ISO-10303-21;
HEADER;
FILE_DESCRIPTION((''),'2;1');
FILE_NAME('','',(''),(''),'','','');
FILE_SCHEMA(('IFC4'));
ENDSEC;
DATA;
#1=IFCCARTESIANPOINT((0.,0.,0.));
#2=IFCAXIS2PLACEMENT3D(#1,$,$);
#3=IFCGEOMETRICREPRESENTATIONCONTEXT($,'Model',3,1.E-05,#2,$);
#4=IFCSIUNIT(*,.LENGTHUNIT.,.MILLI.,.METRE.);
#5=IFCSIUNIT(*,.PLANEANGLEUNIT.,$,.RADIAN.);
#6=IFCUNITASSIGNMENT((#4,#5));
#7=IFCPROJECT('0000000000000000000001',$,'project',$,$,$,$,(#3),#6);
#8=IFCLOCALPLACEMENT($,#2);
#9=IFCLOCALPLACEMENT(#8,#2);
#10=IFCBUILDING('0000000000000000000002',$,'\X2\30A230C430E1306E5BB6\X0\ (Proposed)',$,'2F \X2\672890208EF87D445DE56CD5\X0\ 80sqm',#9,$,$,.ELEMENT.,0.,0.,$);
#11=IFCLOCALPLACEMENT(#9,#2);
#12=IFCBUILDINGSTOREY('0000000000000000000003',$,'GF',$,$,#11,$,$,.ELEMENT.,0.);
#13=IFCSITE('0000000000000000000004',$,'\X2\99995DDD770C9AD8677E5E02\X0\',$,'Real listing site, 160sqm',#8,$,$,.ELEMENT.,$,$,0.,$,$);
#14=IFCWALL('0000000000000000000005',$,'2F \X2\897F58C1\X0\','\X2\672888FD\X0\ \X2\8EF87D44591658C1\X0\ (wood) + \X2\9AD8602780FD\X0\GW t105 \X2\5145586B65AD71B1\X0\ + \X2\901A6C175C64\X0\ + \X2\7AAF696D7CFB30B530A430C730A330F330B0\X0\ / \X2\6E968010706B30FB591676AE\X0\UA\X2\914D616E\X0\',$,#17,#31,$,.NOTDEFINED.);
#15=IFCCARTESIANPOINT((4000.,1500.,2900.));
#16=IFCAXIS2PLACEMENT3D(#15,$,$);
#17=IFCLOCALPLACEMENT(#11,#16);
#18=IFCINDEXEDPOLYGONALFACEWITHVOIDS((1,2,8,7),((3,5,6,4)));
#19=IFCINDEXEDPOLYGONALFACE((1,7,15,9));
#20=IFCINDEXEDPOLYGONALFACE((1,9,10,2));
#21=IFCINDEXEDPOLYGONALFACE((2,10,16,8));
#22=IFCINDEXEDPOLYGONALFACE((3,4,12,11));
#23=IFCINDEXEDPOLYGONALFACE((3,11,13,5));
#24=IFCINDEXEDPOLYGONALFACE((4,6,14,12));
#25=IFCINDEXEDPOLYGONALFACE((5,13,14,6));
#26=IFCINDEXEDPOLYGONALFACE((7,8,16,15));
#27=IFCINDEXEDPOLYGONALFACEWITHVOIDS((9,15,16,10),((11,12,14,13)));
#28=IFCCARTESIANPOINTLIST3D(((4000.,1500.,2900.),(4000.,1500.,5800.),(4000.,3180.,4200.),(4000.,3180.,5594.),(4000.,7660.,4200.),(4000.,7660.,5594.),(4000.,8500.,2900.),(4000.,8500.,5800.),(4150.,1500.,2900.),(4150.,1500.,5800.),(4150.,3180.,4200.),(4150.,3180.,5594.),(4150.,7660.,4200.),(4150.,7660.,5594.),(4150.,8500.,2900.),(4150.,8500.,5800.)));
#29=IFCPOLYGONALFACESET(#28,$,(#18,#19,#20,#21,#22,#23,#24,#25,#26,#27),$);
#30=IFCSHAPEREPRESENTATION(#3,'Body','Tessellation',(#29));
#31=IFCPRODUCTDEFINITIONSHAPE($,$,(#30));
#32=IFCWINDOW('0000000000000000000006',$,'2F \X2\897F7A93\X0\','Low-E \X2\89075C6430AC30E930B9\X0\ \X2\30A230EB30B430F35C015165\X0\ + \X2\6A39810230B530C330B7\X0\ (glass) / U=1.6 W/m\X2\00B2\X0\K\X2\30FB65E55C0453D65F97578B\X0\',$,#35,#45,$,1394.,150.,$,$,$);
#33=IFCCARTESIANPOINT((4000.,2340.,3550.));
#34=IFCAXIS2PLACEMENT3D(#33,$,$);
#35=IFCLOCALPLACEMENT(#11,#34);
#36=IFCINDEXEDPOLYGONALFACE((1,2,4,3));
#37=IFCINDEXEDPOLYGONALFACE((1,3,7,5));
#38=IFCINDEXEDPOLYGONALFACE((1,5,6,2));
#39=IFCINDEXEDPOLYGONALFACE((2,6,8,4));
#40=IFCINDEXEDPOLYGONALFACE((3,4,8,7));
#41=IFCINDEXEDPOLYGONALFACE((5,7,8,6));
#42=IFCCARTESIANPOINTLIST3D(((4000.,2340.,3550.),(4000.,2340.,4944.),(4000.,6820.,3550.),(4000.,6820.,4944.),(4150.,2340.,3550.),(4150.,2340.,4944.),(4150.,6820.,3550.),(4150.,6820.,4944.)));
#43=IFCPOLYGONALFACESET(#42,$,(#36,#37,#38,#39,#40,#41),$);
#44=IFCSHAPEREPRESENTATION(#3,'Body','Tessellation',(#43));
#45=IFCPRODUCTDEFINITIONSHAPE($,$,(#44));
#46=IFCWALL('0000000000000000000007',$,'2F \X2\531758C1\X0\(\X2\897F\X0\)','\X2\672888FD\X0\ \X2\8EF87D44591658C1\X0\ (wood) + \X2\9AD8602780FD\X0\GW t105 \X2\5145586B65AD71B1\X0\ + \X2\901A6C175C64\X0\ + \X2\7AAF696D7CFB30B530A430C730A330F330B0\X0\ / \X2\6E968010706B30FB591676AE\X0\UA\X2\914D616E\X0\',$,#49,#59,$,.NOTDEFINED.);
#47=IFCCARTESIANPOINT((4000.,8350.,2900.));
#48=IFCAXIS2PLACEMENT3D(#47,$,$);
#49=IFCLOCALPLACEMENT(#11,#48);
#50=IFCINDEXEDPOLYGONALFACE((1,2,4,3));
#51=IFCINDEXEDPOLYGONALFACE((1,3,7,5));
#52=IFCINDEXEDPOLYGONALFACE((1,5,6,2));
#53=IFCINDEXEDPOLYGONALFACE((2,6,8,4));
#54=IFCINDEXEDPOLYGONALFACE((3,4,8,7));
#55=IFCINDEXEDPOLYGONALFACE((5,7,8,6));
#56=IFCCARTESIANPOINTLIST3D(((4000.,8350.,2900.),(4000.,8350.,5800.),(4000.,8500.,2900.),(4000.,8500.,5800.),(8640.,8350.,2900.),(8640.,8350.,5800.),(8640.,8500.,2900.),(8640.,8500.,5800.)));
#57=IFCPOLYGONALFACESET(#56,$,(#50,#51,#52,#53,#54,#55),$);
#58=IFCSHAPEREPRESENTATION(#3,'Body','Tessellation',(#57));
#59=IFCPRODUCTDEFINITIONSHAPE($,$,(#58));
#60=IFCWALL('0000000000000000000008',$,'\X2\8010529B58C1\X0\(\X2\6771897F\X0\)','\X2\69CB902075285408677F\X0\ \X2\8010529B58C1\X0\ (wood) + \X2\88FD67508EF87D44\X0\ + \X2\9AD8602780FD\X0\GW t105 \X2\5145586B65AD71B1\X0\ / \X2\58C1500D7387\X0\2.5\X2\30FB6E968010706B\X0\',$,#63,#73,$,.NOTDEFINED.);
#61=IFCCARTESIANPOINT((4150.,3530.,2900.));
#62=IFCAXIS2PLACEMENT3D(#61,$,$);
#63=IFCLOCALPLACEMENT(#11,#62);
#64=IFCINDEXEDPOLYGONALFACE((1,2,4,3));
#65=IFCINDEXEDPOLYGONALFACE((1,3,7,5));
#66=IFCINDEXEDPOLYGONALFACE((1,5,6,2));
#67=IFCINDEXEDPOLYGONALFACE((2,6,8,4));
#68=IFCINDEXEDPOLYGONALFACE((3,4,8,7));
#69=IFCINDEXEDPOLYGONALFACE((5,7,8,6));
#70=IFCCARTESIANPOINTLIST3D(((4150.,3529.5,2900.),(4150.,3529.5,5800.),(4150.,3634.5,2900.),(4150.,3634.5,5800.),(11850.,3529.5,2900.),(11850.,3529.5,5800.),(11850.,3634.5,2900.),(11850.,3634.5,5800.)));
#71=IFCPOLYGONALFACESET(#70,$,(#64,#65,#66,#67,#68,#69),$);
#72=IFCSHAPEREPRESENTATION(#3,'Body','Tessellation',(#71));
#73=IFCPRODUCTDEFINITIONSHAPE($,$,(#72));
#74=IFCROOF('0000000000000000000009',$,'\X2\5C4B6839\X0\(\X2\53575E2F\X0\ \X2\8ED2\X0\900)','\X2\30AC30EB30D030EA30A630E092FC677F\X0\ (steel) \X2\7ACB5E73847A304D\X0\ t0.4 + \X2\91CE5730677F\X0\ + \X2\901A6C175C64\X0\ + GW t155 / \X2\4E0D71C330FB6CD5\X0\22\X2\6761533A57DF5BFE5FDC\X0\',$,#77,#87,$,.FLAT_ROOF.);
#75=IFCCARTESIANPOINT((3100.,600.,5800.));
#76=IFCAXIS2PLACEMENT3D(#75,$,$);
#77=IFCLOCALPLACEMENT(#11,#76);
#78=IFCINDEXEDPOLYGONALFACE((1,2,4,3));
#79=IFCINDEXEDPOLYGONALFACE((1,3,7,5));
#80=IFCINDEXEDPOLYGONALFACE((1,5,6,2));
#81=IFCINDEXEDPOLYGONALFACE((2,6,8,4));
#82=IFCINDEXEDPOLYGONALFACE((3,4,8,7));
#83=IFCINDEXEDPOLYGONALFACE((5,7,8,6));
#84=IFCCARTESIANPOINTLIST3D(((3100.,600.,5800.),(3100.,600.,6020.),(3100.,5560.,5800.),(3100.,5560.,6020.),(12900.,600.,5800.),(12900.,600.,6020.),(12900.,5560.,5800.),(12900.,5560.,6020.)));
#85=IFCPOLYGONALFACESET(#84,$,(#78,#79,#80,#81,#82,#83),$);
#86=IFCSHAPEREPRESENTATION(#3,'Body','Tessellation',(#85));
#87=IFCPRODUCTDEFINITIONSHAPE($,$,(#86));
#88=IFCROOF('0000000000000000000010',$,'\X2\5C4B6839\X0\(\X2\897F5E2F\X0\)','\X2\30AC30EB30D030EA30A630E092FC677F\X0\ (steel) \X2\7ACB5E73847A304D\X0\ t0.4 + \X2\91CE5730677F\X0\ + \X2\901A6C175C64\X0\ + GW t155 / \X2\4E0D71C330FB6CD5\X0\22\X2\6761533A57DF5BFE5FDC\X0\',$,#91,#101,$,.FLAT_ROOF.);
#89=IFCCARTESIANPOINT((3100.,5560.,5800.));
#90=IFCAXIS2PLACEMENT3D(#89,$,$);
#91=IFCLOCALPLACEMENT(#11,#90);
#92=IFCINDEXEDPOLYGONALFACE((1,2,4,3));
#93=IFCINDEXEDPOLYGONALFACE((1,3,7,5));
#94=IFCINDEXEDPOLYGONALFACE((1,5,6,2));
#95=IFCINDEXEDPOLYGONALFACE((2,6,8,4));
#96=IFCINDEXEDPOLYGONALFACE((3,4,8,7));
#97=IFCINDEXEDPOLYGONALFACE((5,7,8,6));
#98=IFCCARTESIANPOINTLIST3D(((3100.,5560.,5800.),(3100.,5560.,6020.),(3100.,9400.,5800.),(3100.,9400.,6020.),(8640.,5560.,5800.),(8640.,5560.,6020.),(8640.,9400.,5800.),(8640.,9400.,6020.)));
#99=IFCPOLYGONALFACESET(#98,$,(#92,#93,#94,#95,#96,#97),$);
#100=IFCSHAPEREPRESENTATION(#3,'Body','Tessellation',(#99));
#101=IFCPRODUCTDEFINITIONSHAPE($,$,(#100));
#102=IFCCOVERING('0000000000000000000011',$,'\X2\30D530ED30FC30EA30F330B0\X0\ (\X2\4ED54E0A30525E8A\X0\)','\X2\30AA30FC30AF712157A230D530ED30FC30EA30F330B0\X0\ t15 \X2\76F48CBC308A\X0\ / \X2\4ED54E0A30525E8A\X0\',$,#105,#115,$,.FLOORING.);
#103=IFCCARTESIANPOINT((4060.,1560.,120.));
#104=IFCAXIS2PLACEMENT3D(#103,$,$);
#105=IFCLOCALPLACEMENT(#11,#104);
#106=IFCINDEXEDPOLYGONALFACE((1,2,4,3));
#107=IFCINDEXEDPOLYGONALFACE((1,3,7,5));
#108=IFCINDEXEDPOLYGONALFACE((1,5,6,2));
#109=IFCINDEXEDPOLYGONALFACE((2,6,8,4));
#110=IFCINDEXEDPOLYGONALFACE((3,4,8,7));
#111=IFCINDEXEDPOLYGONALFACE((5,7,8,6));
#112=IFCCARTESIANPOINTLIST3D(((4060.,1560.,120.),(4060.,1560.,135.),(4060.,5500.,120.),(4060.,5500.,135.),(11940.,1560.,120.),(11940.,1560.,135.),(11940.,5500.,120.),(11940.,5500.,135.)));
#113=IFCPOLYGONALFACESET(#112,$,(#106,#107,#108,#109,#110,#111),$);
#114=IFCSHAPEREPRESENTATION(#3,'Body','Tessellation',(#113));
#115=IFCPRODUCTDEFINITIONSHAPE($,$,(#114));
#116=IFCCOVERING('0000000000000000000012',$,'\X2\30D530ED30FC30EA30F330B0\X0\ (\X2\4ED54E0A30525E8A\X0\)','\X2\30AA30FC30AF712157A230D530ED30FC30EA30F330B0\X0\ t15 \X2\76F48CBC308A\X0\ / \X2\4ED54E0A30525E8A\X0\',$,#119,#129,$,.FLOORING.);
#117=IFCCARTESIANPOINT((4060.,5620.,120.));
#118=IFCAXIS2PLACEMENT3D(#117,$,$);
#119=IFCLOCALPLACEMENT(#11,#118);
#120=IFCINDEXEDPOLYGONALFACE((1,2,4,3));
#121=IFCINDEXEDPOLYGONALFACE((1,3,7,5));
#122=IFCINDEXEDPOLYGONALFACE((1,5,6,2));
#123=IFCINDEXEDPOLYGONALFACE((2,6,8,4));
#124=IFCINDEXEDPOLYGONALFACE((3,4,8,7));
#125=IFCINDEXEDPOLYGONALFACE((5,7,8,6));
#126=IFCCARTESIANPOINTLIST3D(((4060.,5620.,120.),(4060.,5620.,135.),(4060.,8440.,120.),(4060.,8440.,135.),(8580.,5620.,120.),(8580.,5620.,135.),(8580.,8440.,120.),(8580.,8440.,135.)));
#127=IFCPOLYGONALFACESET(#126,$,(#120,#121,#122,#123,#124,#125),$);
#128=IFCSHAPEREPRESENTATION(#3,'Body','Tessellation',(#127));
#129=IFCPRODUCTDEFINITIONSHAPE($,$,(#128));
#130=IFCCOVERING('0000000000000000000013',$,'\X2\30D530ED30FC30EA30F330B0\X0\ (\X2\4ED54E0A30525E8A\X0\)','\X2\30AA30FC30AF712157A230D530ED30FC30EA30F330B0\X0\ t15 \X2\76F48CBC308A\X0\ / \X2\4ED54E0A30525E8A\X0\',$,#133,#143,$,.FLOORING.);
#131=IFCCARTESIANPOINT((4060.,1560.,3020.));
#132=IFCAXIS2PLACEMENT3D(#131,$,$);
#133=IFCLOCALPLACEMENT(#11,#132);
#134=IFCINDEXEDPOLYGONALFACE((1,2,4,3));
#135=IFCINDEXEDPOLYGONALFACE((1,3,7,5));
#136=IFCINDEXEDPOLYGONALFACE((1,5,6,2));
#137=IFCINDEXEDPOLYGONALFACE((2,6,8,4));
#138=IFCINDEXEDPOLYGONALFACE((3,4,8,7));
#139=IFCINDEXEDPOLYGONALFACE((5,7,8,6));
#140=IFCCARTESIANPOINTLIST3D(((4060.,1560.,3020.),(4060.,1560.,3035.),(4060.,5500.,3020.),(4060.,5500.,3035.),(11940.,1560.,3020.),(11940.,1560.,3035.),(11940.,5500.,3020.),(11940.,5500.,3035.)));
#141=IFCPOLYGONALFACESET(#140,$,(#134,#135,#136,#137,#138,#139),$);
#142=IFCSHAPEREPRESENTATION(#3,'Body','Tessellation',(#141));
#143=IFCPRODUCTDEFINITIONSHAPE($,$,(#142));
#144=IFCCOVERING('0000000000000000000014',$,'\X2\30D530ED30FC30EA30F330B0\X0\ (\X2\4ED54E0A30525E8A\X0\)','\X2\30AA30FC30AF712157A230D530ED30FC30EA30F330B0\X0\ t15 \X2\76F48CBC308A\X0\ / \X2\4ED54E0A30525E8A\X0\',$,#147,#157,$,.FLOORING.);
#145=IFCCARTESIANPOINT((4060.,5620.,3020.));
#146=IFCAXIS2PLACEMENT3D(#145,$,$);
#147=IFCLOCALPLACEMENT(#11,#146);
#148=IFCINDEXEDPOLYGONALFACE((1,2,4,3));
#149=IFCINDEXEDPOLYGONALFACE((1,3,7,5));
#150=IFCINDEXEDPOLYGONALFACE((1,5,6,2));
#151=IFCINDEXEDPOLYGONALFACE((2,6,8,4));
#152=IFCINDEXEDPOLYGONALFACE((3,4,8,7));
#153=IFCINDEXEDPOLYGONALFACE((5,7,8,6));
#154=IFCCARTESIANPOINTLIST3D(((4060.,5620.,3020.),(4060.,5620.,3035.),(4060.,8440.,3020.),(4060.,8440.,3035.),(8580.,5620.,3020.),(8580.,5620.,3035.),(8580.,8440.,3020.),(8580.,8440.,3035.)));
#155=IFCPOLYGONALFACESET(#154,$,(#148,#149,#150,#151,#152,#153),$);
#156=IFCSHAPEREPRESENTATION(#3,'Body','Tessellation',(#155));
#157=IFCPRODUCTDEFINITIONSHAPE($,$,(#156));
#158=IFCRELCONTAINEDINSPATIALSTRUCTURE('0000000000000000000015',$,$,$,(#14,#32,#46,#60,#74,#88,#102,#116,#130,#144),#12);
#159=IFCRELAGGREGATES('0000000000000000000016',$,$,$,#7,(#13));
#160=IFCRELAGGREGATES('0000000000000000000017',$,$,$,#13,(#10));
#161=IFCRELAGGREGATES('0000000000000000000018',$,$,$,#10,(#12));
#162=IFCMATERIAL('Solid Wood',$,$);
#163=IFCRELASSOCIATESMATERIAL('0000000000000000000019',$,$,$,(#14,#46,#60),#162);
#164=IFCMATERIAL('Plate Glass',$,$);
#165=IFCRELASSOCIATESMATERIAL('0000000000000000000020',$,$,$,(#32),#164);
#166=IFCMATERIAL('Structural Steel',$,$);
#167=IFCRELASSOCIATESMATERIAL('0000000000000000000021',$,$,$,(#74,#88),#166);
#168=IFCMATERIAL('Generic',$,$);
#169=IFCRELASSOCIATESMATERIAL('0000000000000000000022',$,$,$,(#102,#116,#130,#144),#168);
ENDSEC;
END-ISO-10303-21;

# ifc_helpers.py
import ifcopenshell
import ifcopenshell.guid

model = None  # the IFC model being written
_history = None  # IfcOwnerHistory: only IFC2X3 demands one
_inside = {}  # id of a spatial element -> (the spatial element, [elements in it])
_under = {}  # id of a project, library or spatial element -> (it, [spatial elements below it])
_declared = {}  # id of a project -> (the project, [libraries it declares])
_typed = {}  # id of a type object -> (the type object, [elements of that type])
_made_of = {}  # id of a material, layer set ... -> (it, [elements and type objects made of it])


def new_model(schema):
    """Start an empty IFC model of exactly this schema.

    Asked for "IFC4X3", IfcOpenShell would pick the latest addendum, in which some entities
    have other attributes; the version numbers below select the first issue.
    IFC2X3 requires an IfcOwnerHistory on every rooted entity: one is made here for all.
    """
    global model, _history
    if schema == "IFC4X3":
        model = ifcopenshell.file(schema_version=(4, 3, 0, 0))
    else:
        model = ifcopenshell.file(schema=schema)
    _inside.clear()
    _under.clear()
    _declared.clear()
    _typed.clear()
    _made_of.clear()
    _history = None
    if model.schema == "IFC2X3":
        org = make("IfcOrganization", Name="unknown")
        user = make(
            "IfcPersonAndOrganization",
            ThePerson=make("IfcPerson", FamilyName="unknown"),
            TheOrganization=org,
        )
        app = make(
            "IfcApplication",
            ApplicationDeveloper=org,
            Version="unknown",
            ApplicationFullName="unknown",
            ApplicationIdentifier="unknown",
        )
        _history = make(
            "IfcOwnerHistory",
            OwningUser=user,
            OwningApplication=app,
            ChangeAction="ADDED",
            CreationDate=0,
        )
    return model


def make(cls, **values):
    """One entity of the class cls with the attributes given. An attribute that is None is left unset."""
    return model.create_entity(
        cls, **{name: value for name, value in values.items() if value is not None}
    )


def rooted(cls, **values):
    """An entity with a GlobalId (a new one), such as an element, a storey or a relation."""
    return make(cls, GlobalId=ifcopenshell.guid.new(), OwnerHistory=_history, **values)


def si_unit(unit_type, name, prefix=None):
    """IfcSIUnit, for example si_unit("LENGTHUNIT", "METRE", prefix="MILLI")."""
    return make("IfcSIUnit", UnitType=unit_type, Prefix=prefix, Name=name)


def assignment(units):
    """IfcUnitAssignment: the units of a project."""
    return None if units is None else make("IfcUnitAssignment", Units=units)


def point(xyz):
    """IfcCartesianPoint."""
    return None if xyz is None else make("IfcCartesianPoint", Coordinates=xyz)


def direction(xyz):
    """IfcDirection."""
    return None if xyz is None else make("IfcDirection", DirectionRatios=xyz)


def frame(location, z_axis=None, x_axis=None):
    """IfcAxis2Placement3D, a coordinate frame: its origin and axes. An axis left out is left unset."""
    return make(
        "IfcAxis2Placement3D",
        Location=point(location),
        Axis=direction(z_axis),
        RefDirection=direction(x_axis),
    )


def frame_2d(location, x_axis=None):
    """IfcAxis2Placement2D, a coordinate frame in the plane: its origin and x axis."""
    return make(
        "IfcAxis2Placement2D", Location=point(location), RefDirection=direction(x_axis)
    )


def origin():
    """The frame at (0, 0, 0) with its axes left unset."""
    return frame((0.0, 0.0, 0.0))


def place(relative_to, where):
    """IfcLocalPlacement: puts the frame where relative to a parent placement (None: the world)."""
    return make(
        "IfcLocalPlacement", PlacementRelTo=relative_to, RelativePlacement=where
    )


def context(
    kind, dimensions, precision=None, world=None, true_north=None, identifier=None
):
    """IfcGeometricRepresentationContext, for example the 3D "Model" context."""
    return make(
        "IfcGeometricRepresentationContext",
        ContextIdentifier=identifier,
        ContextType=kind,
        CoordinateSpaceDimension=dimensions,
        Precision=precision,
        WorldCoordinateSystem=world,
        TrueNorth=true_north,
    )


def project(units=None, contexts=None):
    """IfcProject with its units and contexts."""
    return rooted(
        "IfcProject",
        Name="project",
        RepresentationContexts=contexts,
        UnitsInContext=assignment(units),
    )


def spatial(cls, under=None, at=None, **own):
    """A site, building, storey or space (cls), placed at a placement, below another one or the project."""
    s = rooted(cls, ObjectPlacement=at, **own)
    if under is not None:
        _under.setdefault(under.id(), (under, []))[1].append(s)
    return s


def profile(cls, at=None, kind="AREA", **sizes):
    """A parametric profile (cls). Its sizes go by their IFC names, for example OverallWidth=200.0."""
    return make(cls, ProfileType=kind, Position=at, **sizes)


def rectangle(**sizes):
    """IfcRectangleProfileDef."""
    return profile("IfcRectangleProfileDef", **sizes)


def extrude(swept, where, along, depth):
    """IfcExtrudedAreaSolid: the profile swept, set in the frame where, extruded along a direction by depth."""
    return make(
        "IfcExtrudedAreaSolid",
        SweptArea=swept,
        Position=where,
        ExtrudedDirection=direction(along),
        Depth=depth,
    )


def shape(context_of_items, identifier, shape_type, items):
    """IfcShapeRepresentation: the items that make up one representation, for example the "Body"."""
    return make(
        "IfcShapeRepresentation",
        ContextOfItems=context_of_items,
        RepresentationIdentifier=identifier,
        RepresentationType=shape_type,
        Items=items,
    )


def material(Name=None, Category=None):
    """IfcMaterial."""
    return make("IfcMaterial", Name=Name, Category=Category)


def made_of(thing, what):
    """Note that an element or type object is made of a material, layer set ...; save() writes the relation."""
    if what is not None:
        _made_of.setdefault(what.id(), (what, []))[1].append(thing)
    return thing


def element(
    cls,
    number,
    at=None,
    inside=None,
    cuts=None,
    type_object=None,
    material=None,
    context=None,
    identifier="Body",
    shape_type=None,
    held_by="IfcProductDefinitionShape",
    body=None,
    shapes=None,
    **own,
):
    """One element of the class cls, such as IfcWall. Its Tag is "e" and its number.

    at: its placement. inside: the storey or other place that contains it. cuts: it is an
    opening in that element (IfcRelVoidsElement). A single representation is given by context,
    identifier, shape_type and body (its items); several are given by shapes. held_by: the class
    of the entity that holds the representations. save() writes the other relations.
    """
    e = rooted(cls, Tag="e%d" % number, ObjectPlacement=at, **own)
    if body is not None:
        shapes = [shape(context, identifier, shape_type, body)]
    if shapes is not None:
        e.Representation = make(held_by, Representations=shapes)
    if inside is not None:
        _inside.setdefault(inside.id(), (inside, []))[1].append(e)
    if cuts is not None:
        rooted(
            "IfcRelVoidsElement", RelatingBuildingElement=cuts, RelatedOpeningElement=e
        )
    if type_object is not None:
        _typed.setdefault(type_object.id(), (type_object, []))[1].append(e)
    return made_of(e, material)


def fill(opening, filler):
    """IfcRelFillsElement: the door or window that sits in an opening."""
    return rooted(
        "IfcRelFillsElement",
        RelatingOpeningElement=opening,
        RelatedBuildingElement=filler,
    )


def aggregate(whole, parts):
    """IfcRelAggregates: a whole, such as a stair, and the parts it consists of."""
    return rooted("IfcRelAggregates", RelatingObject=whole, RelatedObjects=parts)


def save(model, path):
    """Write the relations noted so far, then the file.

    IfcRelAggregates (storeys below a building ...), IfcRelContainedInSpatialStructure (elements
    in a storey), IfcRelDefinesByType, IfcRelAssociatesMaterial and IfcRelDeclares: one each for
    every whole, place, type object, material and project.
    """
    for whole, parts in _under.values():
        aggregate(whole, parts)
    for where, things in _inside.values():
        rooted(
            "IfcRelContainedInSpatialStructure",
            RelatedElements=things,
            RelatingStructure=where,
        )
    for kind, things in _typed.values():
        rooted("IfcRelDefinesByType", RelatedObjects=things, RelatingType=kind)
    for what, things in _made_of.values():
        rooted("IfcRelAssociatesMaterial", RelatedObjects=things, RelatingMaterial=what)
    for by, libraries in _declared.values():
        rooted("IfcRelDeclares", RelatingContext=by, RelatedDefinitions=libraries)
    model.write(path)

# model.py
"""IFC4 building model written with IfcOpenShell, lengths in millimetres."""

from ifc_helpers import new_model, si_unit, frame, frame_2d, origin, place, context, project, spatial, rectangle, extrude, material, element, fill, save


model = new_model("IFC4")

# Units and contexts
model_context = context("Model", 3, precision=1e-05, world=origin())
ifc_project = project(units=[si_unit("LENGTHUNIT", "METRE", prefix="MILLI"), si_unit("PLANEANGLEUNIT", "RADIAN")], contexts=[model_context])

# Site, building, storey
site_placement = place(None, origin())
site = spatial("IfcSite", under=ifc_project, at=site_placement, Name="香川県高松市", ObjectType="Real listing site, 160sqm", CompositionType="ELEMENT", RefElevation=0.0)
building_placement = place(site_placement, origin())
building = spatial("IfcBuilding", under=site, at=building_placement, Name="アツメの家 (Proposed)", ObjectType="2F 木造軸組工法 80sqm", CompositionType="ELEMENT", ElevationOfRefHeight=0.0, ElevationOfTerrain=0.0)
storey_placement = place(building_placement, origin())
storey = spatial("IfcBuildingStorey", under=building, at=storey_placement, Name="GF", CompositionType="ELEMENT", Elevation=0.0)

# Shared definitions
ifc_material_1 = material(Name="Solid Wood")

# Shared definitions
ifc_material_2 = material(Name="Plate Glass")

# Wall, opening, window
wall_1_placement = place(storey_placement, frame((4000.0, 1500.0, 2900.0)))
wall_1 = element("IfcWall", 1, at=wall_1_placement, inside=storey, material=ifc_material_1, Name="2F 西壁", Description="木製 軸組外壁 (wood) + 高性能GW t105 充填断熱 + 通気層 + 窯業系サイディング / 準耐火・外皮UA配慮", PredefinedType="NOTDEFINED", context=model_context, shape_type="SweptSolid", body=[
    extrude(rectangle(XDim=150.0, YDim=7000.0, at=frame_2d((75.0, 3500.0))), frame((4000.0, 1500.0, 2900.0)), (0.0, 0.0, 1.0), 2900.0),
])
opening_1_placement = place(storey_placement, frame((4000.0, 2340.0, 3550.0)))
opening_1 = element("IfcOpeningElement", 2, at=opening_1_placement, cuts=wall_1, PredefinedType="NOTDEFINED", context=model_context, shape_type="SweptSolid", body=[
    extrude(rectangle(XDim=150.0, YDim=4480.0, at=frame_2d((75.0, 2240.0))), frame((4000.0, 2340.0, 3550.0)), (0.0, 0.0, 1.0), 1394.0),
])
window_1_placement = place(storey_placement, frame((4000.0, 2340.0, 3550.0)))
window_1 = element("IfcWindow", 3, at=window_1_placement, inside=storey, material=ifc_material_2, Name="2F 西窓", Description="Low-E 複層ガラス アルゴン封入 + 樹脂サッシ (glass) / U=1.6 W/m²K・日射取得型", OverallHeight=1394.0, OverallWidth=150.0, context=model_context, shape_type="SweptSolid", body=[
    extrude(rectangle(XDim=150.0, YDim=4480.0, at=frame_2d((75.0, 2240.0))), frame((4000.0, 2340.0, 3550.0)), (0.0, 0.0, 1.0), 1394.0),
])
fill(opening_1, window_1)

# Walls
wall_2_placement = place(storey_placement, frame((4000.0, 8350.0, 2900.0)))
element("IfcWall", 4, at=wall_2_placement, inside=storey, material=ifc_material_1, Name="2F 北壁(西)", Description="木製 軸組外壁 (wood) + 高性能GW t105 充填断熱 + 通気層 + 窯業系サイディング / 準耐火・外皮UA配慮", PredefinedType="NOTDEFINED", context=model_context, shape_type="SweptSolid", body=[
    extrude(rectangle(XDim=4640.0, YDim=150.0, at=frame_2d((2320.0, 75.0))), frame((4000.0, 8350.0, 2900.0)), (0.0, 0.0, 1.0), 2900.0),
])
wall_3_placement = place(storey_placement, frame((4150.0, 3530.0, 2900.0)))
element("IfcWall", 5, at=wall_3_placement, inside=storey, material=ifc_material_1, Name="耐力壁(東西)", Description="構造用合板 耐力壁 (wood) + 製材軸組 + 高性能GW t105 充填断熱 / 壁倍率2.5・準耐火", PredefinedType="NOTDEFINED", context=model_context, shape_type="SweptSolid", body=[
    extrude(rectangle(XDim=7700.0, YDim=105.0, at=frame_2d((3850.0, 52.0))), frame((4150.0, 3530.0, 2900.0)), (0.0, 0.0, 1.0), 2900.0),
])

# Roofs
ifc_material_3 = material(Name="Structural Steel")
roof_1_placement = place(storey_placement, frame((3100.0, 600.0, 5800.0)))
element("IfcRoof", 6, at=roof_1_placement, inside=storey, material=ifc_material_3, Name="屋根(南帯 軒900)", Description="ガルバリウム鋼板 (steel) 立平葺き t0.4 + 野地板 + 通気層 + GW t155 / 不燃・法22条区域対応", PredefinedType="FLAT_ROOF", context=model_context, shape_type="SweptSolid", body=[
    extrude(rectangle(XDim=9800.0, YDim=4960.0, at=frame_2d((4900.0, 2480.0))), frame((3100.0, 600.0, 5800.0)), (0.0, 0.0, 1.0), 220.0),
])
roof_2_placement = place(storey_placement, frame((3100.0, 5560.0, 5800.0)))
element("IfcRoof", 7, at=roof_2_placement, inside=storey, material=ifc_material_3, Name="屋根(西帯)", Description="ガルバリウム鋼板 (steel) 立平葺き t0.4 + 野地板 + 通気層 + GW t155 / 不燃・法22条区域対応", PredefinedType="FLAT_ROOF", context=model_context, shape_type="SweptSolid", body=[
    extrude(rectangle(XDim=5540.0, YDim=3840.0, at=frame_2d((2770.0, 1920.0))), frame((3100.0, 5560.0, 5800.0)), (0.0, 0.0, 1.0), 220.0),
])

# Coverings
ifc_material_4 = material(Name="Generic")
covering_1_placement = place(storey_placement, frame((4060.0, 1560.0, 120.0)))
element("IfcCovering", 8, at=covering_1_placement, inside=storey, material=ifc_material_4, Name="フローリング (仕上げ床)", Description="オーク無垢フローリング t15 直貼り / 仕上げ床", PredefinedType="FLOORING", context=model_context, shape_type="SweptSolid", body=[
    extrude(rectangle(XDim=7880.0, YDim=3940.0, at=frame_2d((3940.0, 1970.0))), frame((4060.0, 1560.0, 120.0)), (0.0, 0.0, 1.0), 15.0),
])
covering_2_placement = place(storey_placement, frame((4060.0, 5620.0, 120.0)))
element("IfcCovering", 9, at=covering_2_placement, inside=storey, material=ifc_material_4, Name="フローリング (仕上げ床)", Description="オーク無垢フローリング t15 直貼り / 仕上げ床", PredefinedType="FLOORING", context=model_context, shape_type="SweptSolid", body=[
    extrude(rectangle(XDim=4520.0, YDim=2820.0, at=frame_2d((2260.0, 1410.0))), frame((4060.0, 5620.0, 120.0)), (0.0, 0.0, 1.0), 15.0),
])
covering_3_placement = place(storey_placement, frame((4060.0, 1560.0, 3020.0)))
element("IfcCovering", 10, at=covering_3_placement, inside=storey, material=ifc_material_4, Name="フローリング (仕上げ床)", Description="オーク無垢フローリング t15 直貼り / 仕上げ床", PredefinedType="FLOORING", context=model_context, shape_type="SweptSolid", body=[
    extrude(rectangle(XDim=7880.0, YDim=3940.0, at=frame_2d((3940.0, 1970.0))), frame((4060.0, 1560.0, 3020.0)), (0.0, 0.0, 1.0), 15.0),
])
covering_4_placement = place(storey_placement, frame((4060.0, 5620.0, 3020.0)))
element("IfcCovering", 11, at=covering_4_placement, inside=storey, material=ifc_material_4, Name="フローリング (仕上げ床)", Description="オーク無垢フローリング t15 直貼り / 仕上げ床", PredefinedType="FLOORING", context=model_context, shape_type="SweptSolid", body=[
    extrude(rectangle(XDim=4520.0, YDim=2820.0, at=frame_2d((2260.0, 1410.0))), frame((4060.0, 5620.0, 3020.0)), (0.0, 0.0, 1.0), 15.0),
])

save(model, "model.ifc")
